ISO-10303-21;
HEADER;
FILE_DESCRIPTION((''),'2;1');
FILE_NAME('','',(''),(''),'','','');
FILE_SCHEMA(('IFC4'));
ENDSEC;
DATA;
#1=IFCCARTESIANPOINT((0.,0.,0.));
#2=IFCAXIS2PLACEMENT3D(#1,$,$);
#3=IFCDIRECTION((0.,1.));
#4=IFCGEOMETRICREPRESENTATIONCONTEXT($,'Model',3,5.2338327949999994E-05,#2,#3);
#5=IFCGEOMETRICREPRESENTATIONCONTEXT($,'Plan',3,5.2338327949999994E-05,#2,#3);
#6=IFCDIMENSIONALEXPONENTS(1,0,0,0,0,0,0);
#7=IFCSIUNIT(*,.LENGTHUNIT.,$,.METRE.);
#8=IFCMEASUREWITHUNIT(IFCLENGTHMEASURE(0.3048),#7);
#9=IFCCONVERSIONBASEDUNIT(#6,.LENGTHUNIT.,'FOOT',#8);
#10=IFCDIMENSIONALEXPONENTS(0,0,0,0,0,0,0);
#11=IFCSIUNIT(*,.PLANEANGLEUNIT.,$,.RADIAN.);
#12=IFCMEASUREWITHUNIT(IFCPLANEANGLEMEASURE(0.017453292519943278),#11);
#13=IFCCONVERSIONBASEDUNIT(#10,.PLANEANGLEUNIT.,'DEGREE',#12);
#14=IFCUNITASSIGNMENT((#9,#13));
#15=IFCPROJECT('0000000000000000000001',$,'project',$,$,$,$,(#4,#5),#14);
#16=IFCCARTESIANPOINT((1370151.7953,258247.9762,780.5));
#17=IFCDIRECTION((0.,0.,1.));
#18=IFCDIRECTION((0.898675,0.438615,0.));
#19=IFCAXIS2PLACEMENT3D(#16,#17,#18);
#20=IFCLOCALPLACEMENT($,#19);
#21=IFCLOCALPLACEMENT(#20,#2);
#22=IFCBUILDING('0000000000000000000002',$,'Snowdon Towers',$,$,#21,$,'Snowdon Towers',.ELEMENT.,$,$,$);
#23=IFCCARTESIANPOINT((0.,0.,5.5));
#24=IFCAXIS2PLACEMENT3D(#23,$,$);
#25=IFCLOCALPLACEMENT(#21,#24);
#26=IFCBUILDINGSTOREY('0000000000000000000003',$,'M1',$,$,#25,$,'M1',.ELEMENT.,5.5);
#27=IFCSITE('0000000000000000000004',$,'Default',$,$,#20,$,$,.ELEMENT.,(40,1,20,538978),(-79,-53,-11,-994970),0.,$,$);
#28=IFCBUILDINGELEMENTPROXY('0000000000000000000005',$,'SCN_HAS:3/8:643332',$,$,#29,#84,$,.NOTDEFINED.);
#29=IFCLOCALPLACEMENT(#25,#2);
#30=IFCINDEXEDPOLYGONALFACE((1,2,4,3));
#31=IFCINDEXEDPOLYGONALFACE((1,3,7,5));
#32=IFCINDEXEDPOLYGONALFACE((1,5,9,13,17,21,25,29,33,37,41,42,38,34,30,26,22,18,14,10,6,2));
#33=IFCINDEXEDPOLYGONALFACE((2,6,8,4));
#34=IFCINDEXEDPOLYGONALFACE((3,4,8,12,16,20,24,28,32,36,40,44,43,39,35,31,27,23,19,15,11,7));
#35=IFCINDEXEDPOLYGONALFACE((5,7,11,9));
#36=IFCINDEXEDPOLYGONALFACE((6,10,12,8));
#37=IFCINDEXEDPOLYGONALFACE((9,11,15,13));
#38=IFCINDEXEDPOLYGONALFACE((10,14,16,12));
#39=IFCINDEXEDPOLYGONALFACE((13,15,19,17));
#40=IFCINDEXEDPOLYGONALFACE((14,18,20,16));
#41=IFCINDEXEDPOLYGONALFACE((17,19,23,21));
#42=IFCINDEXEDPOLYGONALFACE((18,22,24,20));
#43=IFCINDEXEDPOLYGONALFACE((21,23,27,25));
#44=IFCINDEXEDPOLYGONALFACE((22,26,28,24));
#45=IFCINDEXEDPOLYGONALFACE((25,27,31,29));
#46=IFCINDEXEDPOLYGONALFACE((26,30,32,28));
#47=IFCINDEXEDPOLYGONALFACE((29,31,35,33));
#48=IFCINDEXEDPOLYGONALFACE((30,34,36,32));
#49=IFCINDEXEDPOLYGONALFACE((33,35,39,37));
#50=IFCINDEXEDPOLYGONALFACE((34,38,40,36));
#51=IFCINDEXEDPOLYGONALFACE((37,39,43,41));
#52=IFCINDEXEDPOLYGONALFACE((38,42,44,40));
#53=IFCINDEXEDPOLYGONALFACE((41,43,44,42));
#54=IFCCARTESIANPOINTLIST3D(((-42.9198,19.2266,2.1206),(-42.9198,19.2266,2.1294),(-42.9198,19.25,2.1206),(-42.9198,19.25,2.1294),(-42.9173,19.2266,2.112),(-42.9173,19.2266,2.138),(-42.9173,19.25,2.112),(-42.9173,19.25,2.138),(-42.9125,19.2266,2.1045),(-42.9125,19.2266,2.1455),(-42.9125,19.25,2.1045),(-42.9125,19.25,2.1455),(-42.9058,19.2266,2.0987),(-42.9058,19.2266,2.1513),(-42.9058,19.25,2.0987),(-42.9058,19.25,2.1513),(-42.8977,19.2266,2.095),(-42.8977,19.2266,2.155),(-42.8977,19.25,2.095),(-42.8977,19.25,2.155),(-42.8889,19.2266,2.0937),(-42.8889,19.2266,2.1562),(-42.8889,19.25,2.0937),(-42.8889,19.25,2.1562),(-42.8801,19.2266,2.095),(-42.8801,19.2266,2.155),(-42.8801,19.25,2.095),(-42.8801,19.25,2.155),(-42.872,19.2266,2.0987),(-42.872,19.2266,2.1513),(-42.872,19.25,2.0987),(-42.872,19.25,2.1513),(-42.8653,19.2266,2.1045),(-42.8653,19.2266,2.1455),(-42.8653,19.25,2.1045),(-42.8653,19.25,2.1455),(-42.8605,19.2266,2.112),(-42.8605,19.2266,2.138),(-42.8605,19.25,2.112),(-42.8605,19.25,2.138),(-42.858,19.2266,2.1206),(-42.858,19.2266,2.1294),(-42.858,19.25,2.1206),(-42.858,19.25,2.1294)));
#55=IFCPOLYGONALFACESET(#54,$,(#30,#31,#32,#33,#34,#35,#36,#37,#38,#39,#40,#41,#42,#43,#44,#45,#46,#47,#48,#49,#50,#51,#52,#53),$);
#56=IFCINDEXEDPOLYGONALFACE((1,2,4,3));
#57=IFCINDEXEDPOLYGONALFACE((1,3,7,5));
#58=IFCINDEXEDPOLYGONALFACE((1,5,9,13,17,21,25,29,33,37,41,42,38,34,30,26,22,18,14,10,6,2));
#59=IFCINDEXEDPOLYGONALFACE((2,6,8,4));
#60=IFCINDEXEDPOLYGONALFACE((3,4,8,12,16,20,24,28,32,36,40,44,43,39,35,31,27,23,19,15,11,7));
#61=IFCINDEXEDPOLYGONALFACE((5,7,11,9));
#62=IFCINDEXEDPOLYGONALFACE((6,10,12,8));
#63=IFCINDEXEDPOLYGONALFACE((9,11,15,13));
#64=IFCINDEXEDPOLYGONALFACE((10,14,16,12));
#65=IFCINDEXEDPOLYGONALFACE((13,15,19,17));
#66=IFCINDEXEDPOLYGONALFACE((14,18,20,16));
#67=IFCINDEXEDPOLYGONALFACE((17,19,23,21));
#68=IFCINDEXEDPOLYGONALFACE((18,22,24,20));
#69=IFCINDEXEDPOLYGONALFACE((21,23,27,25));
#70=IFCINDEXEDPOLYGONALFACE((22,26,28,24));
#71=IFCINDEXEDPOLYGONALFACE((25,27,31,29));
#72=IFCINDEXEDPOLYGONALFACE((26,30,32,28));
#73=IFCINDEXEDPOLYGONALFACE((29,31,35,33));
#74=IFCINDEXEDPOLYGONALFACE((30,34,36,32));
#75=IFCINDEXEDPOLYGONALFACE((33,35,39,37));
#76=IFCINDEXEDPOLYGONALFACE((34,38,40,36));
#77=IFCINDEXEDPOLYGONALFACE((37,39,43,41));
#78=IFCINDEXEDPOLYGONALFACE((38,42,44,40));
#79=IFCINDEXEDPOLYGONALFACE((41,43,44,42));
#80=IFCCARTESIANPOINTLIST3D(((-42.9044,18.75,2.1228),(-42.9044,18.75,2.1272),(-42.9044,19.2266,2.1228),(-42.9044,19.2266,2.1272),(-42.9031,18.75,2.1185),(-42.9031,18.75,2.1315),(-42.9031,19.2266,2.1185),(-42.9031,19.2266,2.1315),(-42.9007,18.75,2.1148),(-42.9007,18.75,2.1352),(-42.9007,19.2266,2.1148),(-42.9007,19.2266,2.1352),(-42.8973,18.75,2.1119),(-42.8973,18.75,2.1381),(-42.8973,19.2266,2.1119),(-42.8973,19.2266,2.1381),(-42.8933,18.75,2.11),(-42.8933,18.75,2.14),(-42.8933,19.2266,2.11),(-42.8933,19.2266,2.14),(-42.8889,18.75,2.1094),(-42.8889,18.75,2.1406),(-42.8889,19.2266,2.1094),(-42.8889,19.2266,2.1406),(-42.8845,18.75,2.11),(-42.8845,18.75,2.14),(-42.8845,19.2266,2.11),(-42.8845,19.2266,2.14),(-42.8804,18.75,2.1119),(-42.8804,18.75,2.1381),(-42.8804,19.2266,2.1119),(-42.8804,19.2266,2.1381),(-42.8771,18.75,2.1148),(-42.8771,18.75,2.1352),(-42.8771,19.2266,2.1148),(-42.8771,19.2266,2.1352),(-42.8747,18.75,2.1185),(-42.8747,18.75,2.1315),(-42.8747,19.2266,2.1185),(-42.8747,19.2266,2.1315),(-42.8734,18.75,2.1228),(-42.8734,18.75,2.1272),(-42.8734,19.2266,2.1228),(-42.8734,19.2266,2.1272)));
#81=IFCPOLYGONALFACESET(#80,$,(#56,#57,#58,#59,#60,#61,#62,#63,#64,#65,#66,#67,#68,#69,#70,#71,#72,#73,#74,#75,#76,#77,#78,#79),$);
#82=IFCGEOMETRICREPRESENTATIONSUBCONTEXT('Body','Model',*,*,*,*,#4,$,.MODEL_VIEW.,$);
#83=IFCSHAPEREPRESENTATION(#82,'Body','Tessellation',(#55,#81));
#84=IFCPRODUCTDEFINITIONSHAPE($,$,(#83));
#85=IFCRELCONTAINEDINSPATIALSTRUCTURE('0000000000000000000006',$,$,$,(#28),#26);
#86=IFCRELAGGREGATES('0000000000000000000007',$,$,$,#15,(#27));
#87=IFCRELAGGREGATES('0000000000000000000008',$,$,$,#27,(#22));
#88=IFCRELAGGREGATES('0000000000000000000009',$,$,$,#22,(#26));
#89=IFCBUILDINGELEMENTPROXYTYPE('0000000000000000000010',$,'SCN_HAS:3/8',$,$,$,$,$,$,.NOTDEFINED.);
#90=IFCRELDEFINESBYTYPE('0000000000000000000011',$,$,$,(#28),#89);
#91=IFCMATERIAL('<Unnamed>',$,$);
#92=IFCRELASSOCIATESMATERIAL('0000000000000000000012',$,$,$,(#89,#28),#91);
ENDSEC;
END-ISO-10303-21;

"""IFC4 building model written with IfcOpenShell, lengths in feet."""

from ifc_helpers import new_model, entity, si_unit, converted_unit, direction, frame, origin, place, context, subcontext, project, spatial, arc, indexed_curve, outline, extrude, source, transform, mapped, material, type_object, type_shapes, element, save


model = new_model("IFC4")

# Units and contexts
model_context = context("Model", 3, precision=5.2338327949999994e-05, world=origin(), true_north=direction((0.0, 1.0)))
plan_context = context("Plan", 3, precision=5.2338327949999994e-05, world=origin(), true_north=direction((0.0, 1.0)))
body_context = subcontext(model_context, "Body", "Model", "MODEL_VIEW")
ifc_project = project(units=[converted_unit("LENGTHUNIT", "FOOT", entity("IfcLengthMeasure", 0.3048), si_unit("LENGTHUNIT", "METRE"), dimensions=[1, 0, 0, 0, 0, 0, 0]), converted_unit("PLANEANGLEUNIT", "DEGREE", entity("IfcPlaneAngleMeasure", 0.017453292519943278), si_unit("PLANEANGLEUNIT", "RADIAN"), dimensions=[0, 0, 0, 0, 0, 0, 0])], contexts=[model_context, plan_context])

# Site, building, storey
site_placement = place(None, frame((1370151.7953, 258247.9762, 780.5), z_axis=(0.0, 0.0, 1.0), x_axis=(0.898675, 0.438615, 0.0)))
site = spatial("IfcSite", under=ifc_project, at=site_placement, Name="Default", CompositionType="ELEMENT", RefLatitude=(40, 1, 20, 538978), RefLongitude=(-79, -53, -11, -994970), RefElevation=0.0)
building_placement = place(site_placement, origin())
building = spatial("IfcBuilding", under=site, at=building_placement, Name="Snowdon Towers", LongName="Snowdon Towers", CompositionType="ELEMENT")
storey_placement = place(building_placement, frame((0.0, 0.0, 5.5)))
storey = spatial("IfcBuildingStorey", under=building, at=storey_placement, Name="M1", LongName="M1", CompositionType="ELEMENT", Elevation=5.5)

# Building element proxy
ifc_material_1 = material(Name="<Unnamed>")
building_element_proxy_type = type_object("IfcBuildingElementProxyType", Name="SCN_HAS:3/8", PredefinedType="NOTDEFINED", material=ifc_material_1)
shared_shape_1 = source(origin(), body_context, "Body", "SweptSolid", [
    extrude(outline(indexed_curve([(-0.0312, 0.0), (0.0, -0.0313), (0.0312, 0.0), (0.0, 0.0312)], segments=[arc(1, 2, 3), arc(3, 4, 1)], self_intersect=False)), frame((0.0, 0.0, -0.5), z_axis=(0.0, 0.0, 1.0), x_axis=(0.0, -1.0, 0.0)), (0.0, 0.0, 1.0), 0.0234),
    extrude(outline(indexed_curve([(-0.0156, 0.0), (0.0, -0.0156), (0.0156, 0.0), (0.0, 0.0156)], segments=[arc(1, 2, 3), arc(3, 4, 1)], self_intersect=False)), frame((0.0, 0.0, -0.4766), z_axis=(0.0, 0.0, 1.0), x_axis=(0.0, -1.0, 0.0)), (0.0, 0.0, 1.0), 0.4766),
])
type_shapes(building_element_proxy_type, [shared_shape_1])
for number, where, z_axis, x_axis, name in (
    (1, (-42.8889, 18.75, 2.125), (0.0, -1.0, 0.0), (1.0, 0.0, 0.0), "SCN_HAS:3/8:643332"),
):
    element("IfcBuildingElementProxy", number, at=place(storey_placement, frame(where, z_axis=z_axis, x_axis=x_axis)), inside=storey, type_object=building_element_proxy_type, material=ifc_material_1, Name=name, PredefinedType="NOTDEFINED", context=body_context, shape_type="MappedRepresentation", body=[
        mapped(shared_shape_1, transform((0.0, 0.0, 0.0), scale=1.0)),
    ])

save(model, "model.ifc")
